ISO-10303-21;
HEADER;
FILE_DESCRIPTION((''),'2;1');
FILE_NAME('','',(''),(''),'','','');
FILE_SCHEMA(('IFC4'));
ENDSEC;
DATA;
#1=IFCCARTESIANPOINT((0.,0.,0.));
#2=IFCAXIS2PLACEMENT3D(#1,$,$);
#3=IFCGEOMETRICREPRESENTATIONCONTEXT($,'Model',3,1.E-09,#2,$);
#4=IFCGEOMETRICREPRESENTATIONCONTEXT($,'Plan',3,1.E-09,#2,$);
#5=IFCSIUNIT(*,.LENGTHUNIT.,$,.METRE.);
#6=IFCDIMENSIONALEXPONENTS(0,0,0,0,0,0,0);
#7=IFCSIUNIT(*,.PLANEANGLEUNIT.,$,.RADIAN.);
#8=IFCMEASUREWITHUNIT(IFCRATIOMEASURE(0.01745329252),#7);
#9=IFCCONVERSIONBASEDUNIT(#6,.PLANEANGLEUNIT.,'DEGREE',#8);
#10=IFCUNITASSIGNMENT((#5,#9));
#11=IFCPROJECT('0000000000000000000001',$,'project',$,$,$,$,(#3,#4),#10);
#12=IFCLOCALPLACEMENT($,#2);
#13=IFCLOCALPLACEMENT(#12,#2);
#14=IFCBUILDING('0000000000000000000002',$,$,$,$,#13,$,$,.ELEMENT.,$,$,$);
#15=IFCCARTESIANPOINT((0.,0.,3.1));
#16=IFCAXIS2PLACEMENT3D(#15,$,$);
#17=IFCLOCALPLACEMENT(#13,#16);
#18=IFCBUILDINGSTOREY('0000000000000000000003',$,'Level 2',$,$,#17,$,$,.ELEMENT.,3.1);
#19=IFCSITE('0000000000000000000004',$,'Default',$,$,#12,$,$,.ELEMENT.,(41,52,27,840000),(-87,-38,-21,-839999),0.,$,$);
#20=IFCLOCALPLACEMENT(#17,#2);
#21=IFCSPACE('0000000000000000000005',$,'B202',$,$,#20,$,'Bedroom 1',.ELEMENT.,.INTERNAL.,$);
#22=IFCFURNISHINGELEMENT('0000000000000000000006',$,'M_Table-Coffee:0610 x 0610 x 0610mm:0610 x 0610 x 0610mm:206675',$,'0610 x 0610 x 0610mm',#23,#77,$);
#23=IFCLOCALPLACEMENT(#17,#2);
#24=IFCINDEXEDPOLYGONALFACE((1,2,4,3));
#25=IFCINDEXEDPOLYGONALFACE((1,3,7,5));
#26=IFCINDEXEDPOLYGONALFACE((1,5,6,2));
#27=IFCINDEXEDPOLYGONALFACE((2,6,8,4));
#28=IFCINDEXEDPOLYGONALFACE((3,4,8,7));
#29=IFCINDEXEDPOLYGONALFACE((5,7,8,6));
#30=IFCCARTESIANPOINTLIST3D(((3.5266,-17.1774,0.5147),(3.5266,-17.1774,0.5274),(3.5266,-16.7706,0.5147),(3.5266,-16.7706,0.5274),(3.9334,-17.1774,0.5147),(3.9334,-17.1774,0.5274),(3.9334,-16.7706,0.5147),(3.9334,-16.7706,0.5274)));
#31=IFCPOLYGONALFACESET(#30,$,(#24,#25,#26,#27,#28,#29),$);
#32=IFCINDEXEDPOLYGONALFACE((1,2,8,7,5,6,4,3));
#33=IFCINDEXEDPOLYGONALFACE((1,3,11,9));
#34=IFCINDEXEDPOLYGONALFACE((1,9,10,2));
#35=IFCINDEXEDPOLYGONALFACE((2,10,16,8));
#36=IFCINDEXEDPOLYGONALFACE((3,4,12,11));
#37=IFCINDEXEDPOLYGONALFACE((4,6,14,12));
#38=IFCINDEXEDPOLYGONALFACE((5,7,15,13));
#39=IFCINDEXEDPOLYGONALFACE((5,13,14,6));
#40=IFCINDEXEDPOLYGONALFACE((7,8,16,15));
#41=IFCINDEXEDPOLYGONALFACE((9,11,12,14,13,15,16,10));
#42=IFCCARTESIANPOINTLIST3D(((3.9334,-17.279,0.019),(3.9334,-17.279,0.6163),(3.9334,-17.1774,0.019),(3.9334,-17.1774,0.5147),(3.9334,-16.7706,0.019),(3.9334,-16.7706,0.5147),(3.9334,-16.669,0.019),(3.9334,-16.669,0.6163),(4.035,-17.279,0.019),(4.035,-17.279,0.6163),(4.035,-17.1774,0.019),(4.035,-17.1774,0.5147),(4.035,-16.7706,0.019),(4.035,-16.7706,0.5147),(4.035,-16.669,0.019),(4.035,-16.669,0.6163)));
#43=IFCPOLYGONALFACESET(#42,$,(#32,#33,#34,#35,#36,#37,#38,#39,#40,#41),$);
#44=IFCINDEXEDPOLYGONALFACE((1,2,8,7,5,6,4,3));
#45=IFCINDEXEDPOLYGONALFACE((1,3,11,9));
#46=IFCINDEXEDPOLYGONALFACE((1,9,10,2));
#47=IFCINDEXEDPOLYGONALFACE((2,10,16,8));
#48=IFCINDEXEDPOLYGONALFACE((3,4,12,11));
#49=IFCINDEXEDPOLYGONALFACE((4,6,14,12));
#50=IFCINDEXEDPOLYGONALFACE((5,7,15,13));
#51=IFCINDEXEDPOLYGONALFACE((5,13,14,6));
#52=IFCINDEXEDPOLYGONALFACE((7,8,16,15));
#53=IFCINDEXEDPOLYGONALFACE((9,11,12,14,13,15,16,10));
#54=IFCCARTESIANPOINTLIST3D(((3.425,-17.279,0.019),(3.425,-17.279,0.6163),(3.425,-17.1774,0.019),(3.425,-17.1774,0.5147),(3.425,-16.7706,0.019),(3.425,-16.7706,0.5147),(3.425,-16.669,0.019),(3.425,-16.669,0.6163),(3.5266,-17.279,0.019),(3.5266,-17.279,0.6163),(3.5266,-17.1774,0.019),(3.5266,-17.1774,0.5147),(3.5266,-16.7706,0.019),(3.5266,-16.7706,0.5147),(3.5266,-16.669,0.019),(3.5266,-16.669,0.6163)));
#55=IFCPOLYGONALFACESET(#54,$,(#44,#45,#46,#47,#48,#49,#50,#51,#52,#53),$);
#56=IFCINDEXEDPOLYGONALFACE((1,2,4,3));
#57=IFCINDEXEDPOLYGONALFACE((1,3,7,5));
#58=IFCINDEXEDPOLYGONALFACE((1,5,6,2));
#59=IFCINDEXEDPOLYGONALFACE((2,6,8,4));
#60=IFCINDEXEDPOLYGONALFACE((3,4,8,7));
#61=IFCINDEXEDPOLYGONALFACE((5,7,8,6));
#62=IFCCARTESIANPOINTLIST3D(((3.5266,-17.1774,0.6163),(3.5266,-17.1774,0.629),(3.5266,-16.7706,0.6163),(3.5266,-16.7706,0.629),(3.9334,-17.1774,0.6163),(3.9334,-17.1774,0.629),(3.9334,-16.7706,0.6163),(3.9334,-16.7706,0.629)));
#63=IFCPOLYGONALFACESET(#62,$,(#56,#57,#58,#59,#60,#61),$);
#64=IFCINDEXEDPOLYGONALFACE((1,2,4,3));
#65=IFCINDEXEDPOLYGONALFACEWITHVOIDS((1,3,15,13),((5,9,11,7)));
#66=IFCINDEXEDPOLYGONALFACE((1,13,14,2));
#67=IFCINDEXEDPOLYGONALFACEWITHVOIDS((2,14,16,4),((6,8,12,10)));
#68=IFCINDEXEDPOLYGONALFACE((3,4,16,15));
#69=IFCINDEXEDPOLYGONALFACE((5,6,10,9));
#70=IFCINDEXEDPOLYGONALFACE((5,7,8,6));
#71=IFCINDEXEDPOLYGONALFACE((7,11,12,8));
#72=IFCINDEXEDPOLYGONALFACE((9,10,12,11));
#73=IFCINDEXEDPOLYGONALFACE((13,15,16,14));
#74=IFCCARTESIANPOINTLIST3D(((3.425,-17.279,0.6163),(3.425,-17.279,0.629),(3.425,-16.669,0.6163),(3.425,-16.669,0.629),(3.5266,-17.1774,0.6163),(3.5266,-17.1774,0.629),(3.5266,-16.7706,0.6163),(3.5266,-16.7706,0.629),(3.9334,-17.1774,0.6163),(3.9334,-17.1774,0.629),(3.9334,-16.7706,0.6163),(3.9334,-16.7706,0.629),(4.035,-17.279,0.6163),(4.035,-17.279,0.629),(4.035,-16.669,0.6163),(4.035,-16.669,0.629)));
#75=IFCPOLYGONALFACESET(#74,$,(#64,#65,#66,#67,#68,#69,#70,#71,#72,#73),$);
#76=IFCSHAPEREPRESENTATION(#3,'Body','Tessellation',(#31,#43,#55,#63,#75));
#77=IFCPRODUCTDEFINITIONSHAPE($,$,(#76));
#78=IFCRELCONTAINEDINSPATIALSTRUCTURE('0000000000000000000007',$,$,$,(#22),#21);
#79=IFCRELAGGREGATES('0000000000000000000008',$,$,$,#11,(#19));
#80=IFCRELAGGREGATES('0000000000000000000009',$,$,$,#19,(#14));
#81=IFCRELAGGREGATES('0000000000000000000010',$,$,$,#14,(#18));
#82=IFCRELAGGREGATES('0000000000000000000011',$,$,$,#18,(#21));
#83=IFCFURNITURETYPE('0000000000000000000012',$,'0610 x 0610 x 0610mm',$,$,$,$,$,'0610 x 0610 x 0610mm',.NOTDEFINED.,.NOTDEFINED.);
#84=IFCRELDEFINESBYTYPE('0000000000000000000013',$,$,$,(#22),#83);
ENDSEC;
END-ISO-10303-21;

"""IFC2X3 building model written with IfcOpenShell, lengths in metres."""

from ifc_helpers import new_model, entity, si_unit, converted_unit, frame, origin, origin_2d_with_axis, place, context, project, spatial, polyline, rectangle, outline, extrude, source, transform, mapped, type_object, type_shapes, element, save


model = new_model("IFC2X3")

# Units and contexts
model_context = context("Model", 3, precision=1e-09, world=origin())
plan_context = context("Plan", 3, precision=1e-09, world=origin())
ifc_project = project(units=[si_unit("LENGTHUNIT", "METRE"), converted_unit("PLANEANGLEUNIT", "DEGREE", entity("IfcRatioMeasure", 0.01745329252), si_unit("PLANEANGLEUNIT", "RADIAN"), dimensions=[0, 0, 0, 0, 0, 0, 0])], contexts=[model_context, plan_context])

# Site, building, storey
site_placement = place(None, origin())
site = spatial("IfcSite", under=ifc_project, at=site_placement, Name="Default", CompositionType="ELEMENT", RefLatitude=(41, 52, 27, 840000), RefLongitude=(-87, -38, -21, -839999), RefElevation=0.0)
building_placement = place(site_placement, origin())
building = spatial("IfcBuilding", under=site, at=building_placement, CompositionType="ELEMENT")
storey_placement = place(building_placement, frame((0.0, 0.0, 3.1)))
storey = spatial("IfcBuildingStorey", under=building, at=storey_placement, Name="Level 2", CompositionType="ELEMENT", Elevation=3.1)

# Shared definitions
space_placement = place(storey_placement, origin())
space = spatial("IfcSpace", under=storey, at=space_placement, Name="B202", LongName="Bedroom 1", CompositionType="ELEMENT", InteriorOrExteriorSpace="INTERNAL")

# Furnishing element
furniture_type = type_object("IfcFurnitureType", Name="0610 x 0610 x 0610mm", ElementType="0610 x 0610 x 0610mm", AssemblyPlace="NOTDEFINED")
shared_shape_1 = source(origin(), model_context, "Body", "SweptSolid", [
    extrude(rectangle(XDim=0.4068, YDim=0.4068, at=origin_2d_with_axis()), frame((0.0183, 0.0952, 0.4957), z_axis=(0.0, 0.0, 1.0), x_axis=(-1.0, 0.0, 0.0)), (0.0, 0.0, 1.0), 0.0127),
    extrude(outline(polyline([(-0.2732, -0.305), (0.3241, -0.305), (0.3241, 0.305), (-0.2732, 0.305), (-0.2732, 0.2034), (0.2225, 0.2034), (0.2225, -0.2034), (-0.2732, -0.2034), (-0.2732, -0.305)])), frame((0.2217, 0.0952, 0.2732), z_axis=(1.0, 0.0, 0.0), x_axis=(0.0, 0.0, 1.0)), (0.0, 0.0, 1.0), 0.1016),
    extrude(outline(polyline([(-0.305, -0.3241), (0.305, -0.3241), (0.305, 0.2732), (0.2034, 0.2732), (0.2034, -0.2225), (-0.2034, -0.2225), (-0.2034, 0.2732), (-0.305, 0.2732), (-0.305, -0.3241)])), frame((-0.2867, 0.0952, 0.2732), z_axis=(1.0, 0.0, 0.0), x_axis=(0.0, -1.0, 0.0)), (0.0, 0.0, 1.0), 0.1016),
    extrude(rectangle(XDim=0.4068, YDim=0.4068, at=origin_2d_with_axis()), frame((0.0183, 0.0952, 0.5973), z_axis=(0.0, 0.0, 1.0), x_axis=(-1.0, 0.0, 0.0)), (0.0, 0.0, 1.0), 0.0127),
    extrude(outline(polyline([(-0.305, -0.305), (0.305, -0.305), (0.305, 0.305), (-0.305, 0.305), (-0.305, -0.305)]), holes=[polyline([(-0.2034, -0.2034), (-0.2034, 0.2034), (0.2034, 0.2034), (0.2034, -0.2034), (-0.2034, -0.2034)])]), frame((0.0183, 0.0952, 0.5973), z_axis=(0.0, 0.0, 1.0), x_axis=(-1.0, 0.0, 0.0)), (0.0, 0.0, 1.0), 0.0127),
])
type_shapes(furniture_type, [shared_shape_1])
furnishing_placement = place(space_placement, frame((3.7117, -17.0692, 0.019)))
element("IfcFurnishingElement", 1, at=furnishing_placement, inside=space, type_object=furniture_type, Name="M_Table-Coffee:0610 x 0610 x 0610mm:0610 x 0610 x 0610mm:206675", ObjectType="0610 x 0610 x 0610mm", context=model_context, shape_type="MappedRepresentation", body=[
    mapped(shared_shape_1, transform((0.0, 0.0, 0.0), scale=1.0)),
])

save(model, "model.ifc")
